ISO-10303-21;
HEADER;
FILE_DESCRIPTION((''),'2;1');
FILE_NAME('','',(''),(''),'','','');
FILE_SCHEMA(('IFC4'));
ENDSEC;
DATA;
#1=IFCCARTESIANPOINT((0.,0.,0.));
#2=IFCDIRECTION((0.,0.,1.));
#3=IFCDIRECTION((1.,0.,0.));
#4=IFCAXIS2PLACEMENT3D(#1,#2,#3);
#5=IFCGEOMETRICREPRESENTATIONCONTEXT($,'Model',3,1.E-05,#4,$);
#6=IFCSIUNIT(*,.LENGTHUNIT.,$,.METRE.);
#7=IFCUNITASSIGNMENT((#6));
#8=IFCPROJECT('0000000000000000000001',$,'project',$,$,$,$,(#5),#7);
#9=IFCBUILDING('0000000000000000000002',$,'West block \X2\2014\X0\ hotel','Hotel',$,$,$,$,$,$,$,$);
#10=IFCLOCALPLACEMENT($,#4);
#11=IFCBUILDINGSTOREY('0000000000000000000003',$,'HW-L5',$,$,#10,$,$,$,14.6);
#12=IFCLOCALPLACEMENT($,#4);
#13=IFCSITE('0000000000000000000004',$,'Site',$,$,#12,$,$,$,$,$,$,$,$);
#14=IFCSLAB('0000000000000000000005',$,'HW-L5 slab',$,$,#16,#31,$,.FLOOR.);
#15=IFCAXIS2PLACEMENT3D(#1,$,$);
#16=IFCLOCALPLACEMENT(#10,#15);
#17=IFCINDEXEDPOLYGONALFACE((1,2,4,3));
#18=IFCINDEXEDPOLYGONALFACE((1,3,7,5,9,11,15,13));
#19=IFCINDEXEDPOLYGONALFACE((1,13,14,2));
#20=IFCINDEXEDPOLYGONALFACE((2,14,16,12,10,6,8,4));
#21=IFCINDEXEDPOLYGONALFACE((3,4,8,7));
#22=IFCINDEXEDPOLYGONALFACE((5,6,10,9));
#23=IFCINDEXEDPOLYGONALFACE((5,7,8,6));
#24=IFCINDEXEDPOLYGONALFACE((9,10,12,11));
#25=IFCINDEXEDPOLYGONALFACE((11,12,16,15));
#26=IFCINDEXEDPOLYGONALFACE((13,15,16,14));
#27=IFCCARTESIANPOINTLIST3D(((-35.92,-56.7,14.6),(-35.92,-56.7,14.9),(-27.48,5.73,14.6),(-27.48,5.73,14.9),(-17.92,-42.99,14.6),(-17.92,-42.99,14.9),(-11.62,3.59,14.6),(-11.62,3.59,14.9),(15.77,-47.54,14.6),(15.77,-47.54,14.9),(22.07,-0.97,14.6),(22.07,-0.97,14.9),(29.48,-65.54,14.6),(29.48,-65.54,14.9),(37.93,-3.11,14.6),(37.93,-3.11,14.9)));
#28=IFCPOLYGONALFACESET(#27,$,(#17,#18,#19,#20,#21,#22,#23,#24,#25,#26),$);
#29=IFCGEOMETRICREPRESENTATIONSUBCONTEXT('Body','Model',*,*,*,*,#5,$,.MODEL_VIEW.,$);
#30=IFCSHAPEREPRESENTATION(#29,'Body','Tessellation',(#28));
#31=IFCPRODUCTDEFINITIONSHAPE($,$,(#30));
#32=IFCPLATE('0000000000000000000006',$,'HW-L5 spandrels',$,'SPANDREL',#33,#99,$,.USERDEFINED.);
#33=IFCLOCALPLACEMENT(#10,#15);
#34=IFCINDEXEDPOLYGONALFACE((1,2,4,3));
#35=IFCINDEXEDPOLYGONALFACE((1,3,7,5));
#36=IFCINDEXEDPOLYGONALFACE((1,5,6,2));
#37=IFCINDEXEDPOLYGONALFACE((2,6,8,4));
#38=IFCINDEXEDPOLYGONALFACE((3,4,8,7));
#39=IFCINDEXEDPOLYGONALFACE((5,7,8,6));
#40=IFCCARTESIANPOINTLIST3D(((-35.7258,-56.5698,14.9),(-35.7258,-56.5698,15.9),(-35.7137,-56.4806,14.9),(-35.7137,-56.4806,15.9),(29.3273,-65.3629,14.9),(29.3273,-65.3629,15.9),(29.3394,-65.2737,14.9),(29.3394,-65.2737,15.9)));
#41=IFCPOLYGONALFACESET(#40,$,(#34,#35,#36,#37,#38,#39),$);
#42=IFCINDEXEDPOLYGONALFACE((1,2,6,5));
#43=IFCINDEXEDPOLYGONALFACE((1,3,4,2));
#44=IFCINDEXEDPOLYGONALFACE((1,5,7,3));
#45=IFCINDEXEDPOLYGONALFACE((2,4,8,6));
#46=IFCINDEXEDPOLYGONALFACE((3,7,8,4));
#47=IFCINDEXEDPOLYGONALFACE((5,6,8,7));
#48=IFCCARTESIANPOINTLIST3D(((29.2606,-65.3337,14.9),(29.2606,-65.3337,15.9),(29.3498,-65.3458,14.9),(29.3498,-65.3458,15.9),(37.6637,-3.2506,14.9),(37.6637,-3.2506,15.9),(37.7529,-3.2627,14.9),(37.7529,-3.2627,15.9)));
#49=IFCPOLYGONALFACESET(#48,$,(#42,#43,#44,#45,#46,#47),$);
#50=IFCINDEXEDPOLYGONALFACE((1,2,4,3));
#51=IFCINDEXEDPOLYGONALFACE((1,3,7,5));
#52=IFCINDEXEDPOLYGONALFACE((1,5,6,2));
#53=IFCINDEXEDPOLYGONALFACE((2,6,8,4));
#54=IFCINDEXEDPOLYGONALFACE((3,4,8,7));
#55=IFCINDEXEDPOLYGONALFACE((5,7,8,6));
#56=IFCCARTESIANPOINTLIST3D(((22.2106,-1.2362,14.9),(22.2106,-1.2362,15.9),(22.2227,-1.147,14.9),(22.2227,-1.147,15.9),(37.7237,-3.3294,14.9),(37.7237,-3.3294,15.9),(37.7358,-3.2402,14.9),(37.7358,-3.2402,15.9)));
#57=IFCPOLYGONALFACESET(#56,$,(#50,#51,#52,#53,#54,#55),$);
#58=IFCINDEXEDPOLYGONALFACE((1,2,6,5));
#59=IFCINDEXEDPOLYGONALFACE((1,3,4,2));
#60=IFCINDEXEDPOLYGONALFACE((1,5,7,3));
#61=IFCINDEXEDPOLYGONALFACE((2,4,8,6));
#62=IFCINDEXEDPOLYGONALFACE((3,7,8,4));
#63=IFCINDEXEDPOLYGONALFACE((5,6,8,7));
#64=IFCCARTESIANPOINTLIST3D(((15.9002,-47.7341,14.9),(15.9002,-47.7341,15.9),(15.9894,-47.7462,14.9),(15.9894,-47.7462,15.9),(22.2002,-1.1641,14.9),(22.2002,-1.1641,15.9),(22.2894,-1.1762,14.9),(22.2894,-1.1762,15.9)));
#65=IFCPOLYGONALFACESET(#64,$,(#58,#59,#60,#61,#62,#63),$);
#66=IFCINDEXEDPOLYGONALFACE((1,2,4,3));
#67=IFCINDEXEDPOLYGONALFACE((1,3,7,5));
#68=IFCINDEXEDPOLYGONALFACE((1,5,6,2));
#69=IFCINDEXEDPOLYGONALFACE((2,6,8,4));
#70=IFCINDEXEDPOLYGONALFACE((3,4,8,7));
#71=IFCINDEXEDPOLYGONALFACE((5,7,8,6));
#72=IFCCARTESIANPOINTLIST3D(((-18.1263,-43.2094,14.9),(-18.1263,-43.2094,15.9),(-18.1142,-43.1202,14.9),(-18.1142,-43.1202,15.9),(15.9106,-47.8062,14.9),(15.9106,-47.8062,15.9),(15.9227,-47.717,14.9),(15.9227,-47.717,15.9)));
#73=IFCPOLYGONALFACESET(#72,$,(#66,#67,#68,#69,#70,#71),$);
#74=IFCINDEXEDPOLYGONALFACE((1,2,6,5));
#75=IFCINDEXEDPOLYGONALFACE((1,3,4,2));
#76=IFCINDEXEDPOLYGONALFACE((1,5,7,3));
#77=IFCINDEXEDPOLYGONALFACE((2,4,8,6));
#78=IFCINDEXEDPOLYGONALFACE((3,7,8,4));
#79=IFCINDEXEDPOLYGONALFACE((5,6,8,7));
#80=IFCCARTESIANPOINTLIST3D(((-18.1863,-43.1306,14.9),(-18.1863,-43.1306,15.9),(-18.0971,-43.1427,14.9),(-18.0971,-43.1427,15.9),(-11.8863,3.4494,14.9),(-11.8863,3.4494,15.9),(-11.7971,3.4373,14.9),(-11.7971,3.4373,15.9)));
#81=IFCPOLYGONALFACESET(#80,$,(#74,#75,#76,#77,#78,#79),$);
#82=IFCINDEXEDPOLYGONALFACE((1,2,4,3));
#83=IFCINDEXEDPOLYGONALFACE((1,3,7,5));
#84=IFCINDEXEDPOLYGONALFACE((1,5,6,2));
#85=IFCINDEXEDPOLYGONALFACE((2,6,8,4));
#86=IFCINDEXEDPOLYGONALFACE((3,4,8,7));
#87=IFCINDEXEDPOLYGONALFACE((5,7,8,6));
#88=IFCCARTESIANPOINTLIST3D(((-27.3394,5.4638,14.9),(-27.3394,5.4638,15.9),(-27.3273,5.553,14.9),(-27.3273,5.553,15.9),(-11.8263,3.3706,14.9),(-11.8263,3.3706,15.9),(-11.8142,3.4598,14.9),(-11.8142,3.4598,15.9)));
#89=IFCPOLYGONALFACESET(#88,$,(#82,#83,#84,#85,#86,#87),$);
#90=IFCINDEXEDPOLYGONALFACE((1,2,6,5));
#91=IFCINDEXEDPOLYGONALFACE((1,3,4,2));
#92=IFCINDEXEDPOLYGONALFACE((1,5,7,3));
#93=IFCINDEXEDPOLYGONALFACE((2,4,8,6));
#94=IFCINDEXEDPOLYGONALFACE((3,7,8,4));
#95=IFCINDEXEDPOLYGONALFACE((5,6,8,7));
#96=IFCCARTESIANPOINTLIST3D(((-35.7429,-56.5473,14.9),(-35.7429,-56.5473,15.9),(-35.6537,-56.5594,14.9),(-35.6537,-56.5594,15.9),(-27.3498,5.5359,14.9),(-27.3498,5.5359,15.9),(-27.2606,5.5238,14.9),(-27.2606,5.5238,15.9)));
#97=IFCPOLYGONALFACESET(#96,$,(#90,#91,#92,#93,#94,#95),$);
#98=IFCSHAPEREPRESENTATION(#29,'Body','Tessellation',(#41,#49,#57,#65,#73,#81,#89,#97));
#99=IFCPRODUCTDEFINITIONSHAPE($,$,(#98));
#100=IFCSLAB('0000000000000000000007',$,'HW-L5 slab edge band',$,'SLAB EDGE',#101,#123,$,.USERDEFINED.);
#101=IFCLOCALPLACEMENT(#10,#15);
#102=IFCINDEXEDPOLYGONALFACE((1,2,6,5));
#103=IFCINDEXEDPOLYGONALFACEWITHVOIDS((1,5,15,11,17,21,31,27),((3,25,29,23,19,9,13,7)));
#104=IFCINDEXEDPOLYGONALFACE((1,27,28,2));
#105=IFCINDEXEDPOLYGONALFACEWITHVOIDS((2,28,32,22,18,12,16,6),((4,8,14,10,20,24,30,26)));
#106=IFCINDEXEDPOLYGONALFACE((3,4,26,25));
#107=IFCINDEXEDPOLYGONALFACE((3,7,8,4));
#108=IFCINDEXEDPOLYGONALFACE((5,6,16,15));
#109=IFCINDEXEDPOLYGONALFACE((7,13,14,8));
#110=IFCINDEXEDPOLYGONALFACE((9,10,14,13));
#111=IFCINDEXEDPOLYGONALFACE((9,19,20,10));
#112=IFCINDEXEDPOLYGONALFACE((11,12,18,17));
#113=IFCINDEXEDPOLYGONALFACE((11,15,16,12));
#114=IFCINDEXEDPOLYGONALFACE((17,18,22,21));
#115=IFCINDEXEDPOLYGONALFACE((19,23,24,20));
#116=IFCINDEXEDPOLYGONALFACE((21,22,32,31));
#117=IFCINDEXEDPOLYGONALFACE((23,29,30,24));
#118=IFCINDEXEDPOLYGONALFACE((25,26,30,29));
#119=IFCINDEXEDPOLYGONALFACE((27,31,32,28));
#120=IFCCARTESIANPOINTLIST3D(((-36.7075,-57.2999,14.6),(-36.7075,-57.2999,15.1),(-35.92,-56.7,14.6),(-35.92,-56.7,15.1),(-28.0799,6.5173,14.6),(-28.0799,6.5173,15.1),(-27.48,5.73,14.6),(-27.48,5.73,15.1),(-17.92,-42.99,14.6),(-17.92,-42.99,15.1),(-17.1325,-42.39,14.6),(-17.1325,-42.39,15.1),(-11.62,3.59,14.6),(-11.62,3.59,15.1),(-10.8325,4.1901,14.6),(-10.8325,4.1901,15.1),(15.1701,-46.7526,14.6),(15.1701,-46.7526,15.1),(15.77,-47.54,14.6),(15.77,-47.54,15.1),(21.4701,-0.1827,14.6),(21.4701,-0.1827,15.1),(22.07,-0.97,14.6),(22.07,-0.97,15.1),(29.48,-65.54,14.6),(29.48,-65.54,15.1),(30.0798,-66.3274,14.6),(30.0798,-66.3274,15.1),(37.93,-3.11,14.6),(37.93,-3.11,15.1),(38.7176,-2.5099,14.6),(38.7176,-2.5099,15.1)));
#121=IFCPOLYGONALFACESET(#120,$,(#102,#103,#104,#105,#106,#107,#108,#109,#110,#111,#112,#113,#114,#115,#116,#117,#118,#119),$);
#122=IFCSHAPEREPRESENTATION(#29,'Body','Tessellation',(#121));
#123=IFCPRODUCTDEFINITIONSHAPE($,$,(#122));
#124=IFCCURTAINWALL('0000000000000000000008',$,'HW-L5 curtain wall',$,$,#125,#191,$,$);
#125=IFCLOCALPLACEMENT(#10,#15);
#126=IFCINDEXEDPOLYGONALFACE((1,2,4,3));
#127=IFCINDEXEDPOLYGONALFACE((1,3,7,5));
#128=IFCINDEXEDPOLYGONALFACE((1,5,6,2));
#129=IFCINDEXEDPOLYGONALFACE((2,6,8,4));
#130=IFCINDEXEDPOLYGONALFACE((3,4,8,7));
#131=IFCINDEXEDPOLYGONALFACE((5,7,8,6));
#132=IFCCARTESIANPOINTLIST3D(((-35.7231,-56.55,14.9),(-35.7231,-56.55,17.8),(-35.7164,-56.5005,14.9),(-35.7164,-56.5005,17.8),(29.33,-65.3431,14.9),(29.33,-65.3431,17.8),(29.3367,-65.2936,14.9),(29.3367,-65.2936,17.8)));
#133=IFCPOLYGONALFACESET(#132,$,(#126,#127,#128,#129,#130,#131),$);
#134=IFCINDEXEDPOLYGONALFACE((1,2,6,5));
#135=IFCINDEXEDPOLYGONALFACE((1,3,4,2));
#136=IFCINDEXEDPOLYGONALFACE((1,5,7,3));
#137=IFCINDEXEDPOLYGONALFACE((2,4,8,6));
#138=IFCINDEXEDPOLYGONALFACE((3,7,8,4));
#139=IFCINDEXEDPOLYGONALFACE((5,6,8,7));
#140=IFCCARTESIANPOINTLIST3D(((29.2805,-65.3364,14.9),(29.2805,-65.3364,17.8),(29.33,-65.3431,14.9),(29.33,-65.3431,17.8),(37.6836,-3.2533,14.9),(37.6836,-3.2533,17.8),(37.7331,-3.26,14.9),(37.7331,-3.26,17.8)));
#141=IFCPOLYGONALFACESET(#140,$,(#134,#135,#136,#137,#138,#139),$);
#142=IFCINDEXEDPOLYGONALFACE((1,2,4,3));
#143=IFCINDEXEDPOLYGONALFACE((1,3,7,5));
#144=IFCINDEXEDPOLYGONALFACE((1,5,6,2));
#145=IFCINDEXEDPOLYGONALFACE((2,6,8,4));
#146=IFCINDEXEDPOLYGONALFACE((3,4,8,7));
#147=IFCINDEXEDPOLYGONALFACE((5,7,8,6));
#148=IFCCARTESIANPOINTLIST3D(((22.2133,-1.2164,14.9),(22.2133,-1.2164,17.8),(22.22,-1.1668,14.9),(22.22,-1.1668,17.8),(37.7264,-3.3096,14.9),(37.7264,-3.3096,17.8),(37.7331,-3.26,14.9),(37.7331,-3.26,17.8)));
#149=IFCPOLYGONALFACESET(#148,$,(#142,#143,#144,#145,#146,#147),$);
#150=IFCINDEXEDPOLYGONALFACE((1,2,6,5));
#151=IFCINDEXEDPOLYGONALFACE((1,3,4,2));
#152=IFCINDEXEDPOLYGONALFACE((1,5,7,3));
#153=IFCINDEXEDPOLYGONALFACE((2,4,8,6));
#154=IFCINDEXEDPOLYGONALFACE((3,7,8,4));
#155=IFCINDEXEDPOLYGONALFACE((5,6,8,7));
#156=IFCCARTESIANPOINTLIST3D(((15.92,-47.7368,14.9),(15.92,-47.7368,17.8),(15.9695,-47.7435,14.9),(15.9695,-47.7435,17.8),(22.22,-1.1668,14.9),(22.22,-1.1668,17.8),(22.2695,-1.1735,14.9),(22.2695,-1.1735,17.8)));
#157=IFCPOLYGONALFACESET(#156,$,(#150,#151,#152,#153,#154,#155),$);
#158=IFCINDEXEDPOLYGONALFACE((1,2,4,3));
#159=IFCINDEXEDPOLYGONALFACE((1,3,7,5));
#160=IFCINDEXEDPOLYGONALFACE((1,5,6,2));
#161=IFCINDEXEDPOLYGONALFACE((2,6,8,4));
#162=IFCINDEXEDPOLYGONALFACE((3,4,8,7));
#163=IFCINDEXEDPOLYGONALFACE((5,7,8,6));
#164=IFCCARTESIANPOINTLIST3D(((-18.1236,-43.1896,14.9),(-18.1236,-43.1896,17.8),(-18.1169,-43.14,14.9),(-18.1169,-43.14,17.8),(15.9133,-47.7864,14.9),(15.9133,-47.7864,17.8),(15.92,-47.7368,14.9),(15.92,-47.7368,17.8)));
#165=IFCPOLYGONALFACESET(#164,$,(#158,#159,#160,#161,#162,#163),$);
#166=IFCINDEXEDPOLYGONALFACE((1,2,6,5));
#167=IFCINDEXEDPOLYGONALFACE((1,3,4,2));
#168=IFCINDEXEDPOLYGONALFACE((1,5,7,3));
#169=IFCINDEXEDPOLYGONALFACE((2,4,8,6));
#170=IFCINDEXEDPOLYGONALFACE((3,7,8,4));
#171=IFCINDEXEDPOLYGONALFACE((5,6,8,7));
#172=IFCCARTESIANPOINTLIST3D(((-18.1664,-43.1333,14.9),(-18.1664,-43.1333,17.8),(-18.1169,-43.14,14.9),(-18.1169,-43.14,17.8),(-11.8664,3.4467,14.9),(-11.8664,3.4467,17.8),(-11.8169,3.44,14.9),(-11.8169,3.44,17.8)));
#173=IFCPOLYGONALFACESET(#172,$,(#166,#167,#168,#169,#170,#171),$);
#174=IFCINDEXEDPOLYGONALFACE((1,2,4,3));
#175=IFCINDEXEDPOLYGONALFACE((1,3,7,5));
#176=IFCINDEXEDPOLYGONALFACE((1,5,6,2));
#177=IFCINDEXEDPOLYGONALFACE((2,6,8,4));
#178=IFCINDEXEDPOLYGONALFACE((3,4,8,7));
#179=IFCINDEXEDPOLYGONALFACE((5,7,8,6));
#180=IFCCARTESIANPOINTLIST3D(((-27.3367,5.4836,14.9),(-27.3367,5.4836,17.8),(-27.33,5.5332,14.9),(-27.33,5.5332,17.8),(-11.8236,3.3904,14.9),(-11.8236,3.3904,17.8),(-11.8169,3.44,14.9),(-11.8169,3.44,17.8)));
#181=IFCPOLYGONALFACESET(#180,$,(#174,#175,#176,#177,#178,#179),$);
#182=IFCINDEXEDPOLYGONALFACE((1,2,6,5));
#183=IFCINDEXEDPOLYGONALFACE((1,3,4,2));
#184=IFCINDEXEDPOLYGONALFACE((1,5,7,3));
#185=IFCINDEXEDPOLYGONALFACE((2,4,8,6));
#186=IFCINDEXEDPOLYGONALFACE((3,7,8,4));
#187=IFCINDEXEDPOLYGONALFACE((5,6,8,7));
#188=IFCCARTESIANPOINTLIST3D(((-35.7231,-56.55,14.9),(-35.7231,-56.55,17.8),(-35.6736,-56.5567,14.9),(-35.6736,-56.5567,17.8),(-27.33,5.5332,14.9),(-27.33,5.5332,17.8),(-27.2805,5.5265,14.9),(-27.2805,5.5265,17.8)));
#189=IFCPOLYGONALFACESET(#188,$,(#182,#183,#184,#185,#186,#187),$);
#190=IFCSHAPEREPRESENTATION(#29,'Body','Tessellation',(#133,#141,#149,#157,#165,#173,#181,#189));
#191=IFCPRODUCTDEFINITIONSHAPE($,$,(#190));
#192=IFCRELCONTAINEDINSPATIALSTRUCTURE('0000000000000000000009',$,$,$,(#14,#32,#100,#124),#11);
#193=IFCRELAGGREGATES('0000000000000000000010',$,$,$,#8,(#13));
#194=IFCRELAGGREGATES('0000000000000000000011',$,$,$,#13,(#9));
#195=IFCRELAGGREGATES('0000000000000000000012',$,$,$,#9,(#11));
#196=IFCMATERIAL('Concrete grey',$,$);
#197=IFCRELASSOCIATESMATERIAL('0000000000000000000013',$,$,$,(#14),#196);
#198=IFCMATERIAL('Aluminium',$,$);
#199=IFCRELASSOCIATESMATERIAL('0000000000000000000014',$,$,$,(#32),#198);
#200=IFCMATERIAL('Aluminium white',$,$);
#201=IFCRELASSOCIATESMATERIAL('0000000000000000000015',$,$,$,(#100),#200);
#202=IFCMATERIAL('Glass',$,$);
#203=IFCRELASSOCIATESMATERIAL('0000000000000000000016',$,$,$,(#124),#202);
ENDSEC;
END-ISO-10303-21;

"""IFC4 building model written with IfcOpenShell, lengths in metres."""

from ifc_helpers import new_model, si_unit, frame, origin_with_axes, place, context, subcontext, project, spatial, polyline, outline, extrude, material, element, save


model = new_model("IFC4")

# Units and contexts
model_context = context("Model", 3, precision=1e-05, world=origin_with_axes())
body_context = subcontext(model_context, "Body", "Model", "MODEL_VIEW")
ifc_project = project(units=[si_unit("LENGTHUNIT", "METRE")], contexts=[model_context])

# Site, building, storey
site_placement = place(None, origin_with_axes())
site = spatial("IfcSite", under=ifc_project, at=site_placement, Name="Site")
building = spatial("IfcBuilding", under=site, Name="West block — hotel", Description="Hotel")
storey_placement = place(None, origin_with_axes())
storey = spatial("IfcBuildingStorey", under=building, at=storey_placement, Name="HW-L5", Elevation=14.6)

# Shared definitions
ifc_material_1 = material(Name="Aluminium")

# Slab
ifc_material_2 = material(Name="Concrete grey")
slab_1_placement = place(storey_placement, origin_with_axes())
element("IfcSlab", 1, at=slab_1_placement, inside=storey, material=ifc_material_2, Name="HW-L5 slab", PredefinedType="FLOOR", context=body_context, shape_type="SweptSolid", body=[
    extrude(outline(polyline([(-35.92, -56.7), (29.48, -65.54), (37.93, -3.11), (22.07, -0.97), (15.77, -47.54), (-17.92, -42.99), (-11.62, 3.59), (-27.48, 5.73), (-35.92, -56.7)])), frame((0.0, 0.0, 14.6), z_axis=(0.0, 0.0, 1.0), x_axis=(1.0, 0.0, 0.0)), (0.0, 0.0, 1.0), 0.3),
])

# Plate
plate_placement = place(storey_placement, origin_with_axes())
element("IfcPlate", 2, at=plate_placement, inside=storey, material=ifc_material_1, Name="HW-L5 spandrels", ObjectType="SPANDREL", PredefinedType="USERDEFINED", context=body_context, shape_type="SweptSolid", body=[
    extrude(outline(polyline([(-35.7258, -56.5698), (29.3273, -65.3629), (29.3394, -65.2737), (-35.7137, -56.4806), (-35.7258, -56.5698)])), frame((0.0, 0.0, 14.9), z_axis=(0.0, 0.0, 1.0), x_axis=(1.0, 0.0, 0.0)), (0.0, 0.0, 1.0), 1.0),
    extrude(outline(polyline([(29.3498, -65.3458), (37.7529, -3.2627), (37.6637, -3.2506), (29.2606, -65.3337), (29.3498, -65.3458)])), frame((0.0, 0.0, 14.9), z_axis=(0.0, 0.0, 1.0), x_axis=(1.0, 0.0, 0.0)), (0.0, 0.0, 1.0), 1.0),
    extrude(outline(polyline([(37.7358, -3.2402), (22.2227, -1.147), (22.2106, -1.2362), (37.7237, -3.3294), (37.7358, -3.2402)])), frame((0.0, 0.0, 14.9), z_axis=(0.0, 0.0, 1.0), x_axis=(1.0, 0.0, 0.0)), (0.0, 0.0, 1.0), 1.0),
    extrude(outline(polyline([(22.2002, -1.1641), (15.9002, -47.7341), (15.9894, -47.7462), (22.2894, -1.1762), (22.2002, -1.1641)])), frame((0.0, 0.0, 14.9), z_axis=(0.0, 0.0, 1.0), x_axis=(1.0, 0.0, 0.0)), (0.0, 0.0, 1.0), 1.0),
    extrude(outline(polyline([(15.9227, -47.717), (-18.1142, -43.1202), (-18.1263, -43.2094), (15.9106, -47.8062), (15.9227, -47.717)])), frame((0.0, 0.0, 14.9), z_axis=(0.0, 0.0, 1.0), x_axis=(1.0, 0.0, 0.0)), (0.0, 0.0, 1.0), 1.0),
    extrude(outline(polyline([(-18.0971, -43.1427), (-11.7971, 3.4373), (-11.8863, 3.4494), (-18.1863, -43.1306), (-18.0971, -43.1427)])), frame((0.0, 0.0, 14.9), z_axis=(0.0, 0.0, 1.0), x_axis=(1.0, 0.0, 0.0)), (0.0, 0.0, 1.0), 1.0),
    extrude(outline(polyline([(-11.8142, 3.4598), (-27.3273, 5.553), (-27.3394, 5.4638), (-11.8263, 3.3706), (-11.8142, 3.4598)])), frame((0.0, 0.0, 14.9), z_axis=(0.0, 0.0, 1.0), x_axis=(1.0, 0.0, 0.0)), (0.0, 0.0, 1.0), 1.0),
    extrude(outline(polyline([(-27.3498, 5.5359), (-35.7429, -56.5473), (-35.6537, -56.5594), (-27.2606, 5.5238), (-27.3498, 5.5359)])), frame((0.0, 0.0, 14.9), z_axis=(0.0, 0.0, 1.0), x_axis=(1.0, 0.0, 0.0)), (0.0, 0.0, 1.0), 1.0),
])

# Slab
ifc_material_3 = material(Name="Aluminium white")
slab_2_placement = place(storey_placement, origin_with_axes())
element("IfcSlab", 3, at=slab_2_placement, inside=storey, material=ifc_material_3, Name="HW-L5 slab edge band", ObjectType="SLAB EDGE", PredefinedType="USERDEFINED", context=body_context, shape_type="SweptSolid", body=[
    extrude(outline(polyline([(-36.7075, -57.2999), (30.0798, -66.3274), (38.7176, -2.5099), (21.4701, -0.1827), (15.1701, -46.7526), (-17.1325, -42.39), (-10.8325, 4.1901), (-28.0799, 6.5173), (-36.7075, -57.2999)]), holes=[polyline([(-35.92, -56.7), (29.48, -65.54), (37.93, -3.11), (22.07, -0.97), (15.77, -47.54), (-17.92, -42.99), (-11.62, 3.59), (-27.48, 5.73), (-35.92, -56.7)])]), frame((0.0, 0.0, 14.6), z_axis=(0.0, 0.0, 1.0), x_axis=(1.0, 0.0, 0.0)), (0.0, 0.0, 1.0), 0.5),
])

# Curtain wall
ifc_material_4 = material(Name="Glass")
curtain_wall_placement = place(storey_placement, origin_with_axes())
element("IfcCurtainWall", 4, at=curtain_wall_placement, inside=storey, material=ifc_material_4, Name="HW-L5 curtain wall", context=body_context, shape_type="SweptSolid", body=[
    extrude(outline(polyline([(-35.7231, -56.55), (29.33, -65.3431), (29.3367, -65.2936), (-35.7164, -56.5005), (-35.7231, -56.55)])), frame((0.0, 0.0, 14.9), z_axis=(0.0, 0.0, 1.0), x_axis=(1.0, 0.0, 0.0)), (0.0, 0.0, 1.0), 2.9),
    extrude(outline(polyline([(29.33, -65.3431), (37.7331, -3.26), (37.6836, -3.2533), (29.2805, -65.3364), (29.33, -65.3431)])), frame((0.0, 0.0, 14.9), z_axis=(0.0, 0.0, 1.0), x_axis=(1.0, 0.0, 0.0)), (0.0, 0.0, 1.0), 2.9),
    extrude(outline(polyline([(37.7331, -3.26), (22.22, -1.1668), (22.2133, -1.2164), (37.7264, -3.3096), (37.7331, -3.26)])), frame((0.0, 0.0, 14.9), z_axis=(0.0, 0.0, 1.0), x_axis=(1.0, 0.0, 0.0)), (0.0, 0.0, 1.0), 2.9),
    extrude(outline(polyline([(22.22, -1.1668), (15.92, -47.7368), (15.9695, -47.7435), (22.2695, -1.1735), (22.22, -1.1668)])), frame((0.0, 0.0, 14.9), z_axis=(0.0, 0.0, 1.0), x_axis=(1.0, 0.0, 0.0)), (0.0, 0.0, 1.0), 2.9),
    extrude(outline(polyline([(15.92, -47.7368), (-18.1169, -43.14), (-18.1236, -43.1896), (15.9133, -47.7864), (15.92, -47.7368)])), frame((0.0, 0.0, 14.9), z_axis=(0.0, 0.0, 1.0), x_axis=(1.0, 0.0, 0.0)), (0.0, 0.0, 1.0), 2.9),
    extrude(outline(polyline([(-18.1169, -43.14), (-11.8169, 3.44), (-11.8664, 3.4467), (-18.1664, -43.1333), (-18.1169, -43.14)])), frame((0.0, 0.0, 14.9), z_axis=(0.0, 0.0, 1.0), x_axis=(1.0, 0.0, 0.0)), (0.0, 0.0, 1.0), 2.9),
    extrude(outline(polyline([(-11.8169, 3.44), (-27.33, 5.5332), (-27.3367, 5.4836), (-11.8236, 3.3904), (-11.8169, 3.44)])), frame((0.0, 0.0, 14.9), z_axis=(0.0, 0.0, 1.0), x_axis=(1.0, 0.0, 0.0)), (0.0, 0.0, 1.0), 2.9),
    extrude(outline(polyline([(-27.33, 5.5332), (-35.7231, -56.55), (-35.6736, -56.5567), (-27.2805, 5.5265), (-27.33, 5.5332)])), frame((0.0, 0.0, 14.9), z_axis=(0.0, 0.0, 1.0), x_axis=(1.0, 0.0, 0.0)), (0.0, 0.0, 1.0), 2.9),
])

save(model, "model.ifc")
